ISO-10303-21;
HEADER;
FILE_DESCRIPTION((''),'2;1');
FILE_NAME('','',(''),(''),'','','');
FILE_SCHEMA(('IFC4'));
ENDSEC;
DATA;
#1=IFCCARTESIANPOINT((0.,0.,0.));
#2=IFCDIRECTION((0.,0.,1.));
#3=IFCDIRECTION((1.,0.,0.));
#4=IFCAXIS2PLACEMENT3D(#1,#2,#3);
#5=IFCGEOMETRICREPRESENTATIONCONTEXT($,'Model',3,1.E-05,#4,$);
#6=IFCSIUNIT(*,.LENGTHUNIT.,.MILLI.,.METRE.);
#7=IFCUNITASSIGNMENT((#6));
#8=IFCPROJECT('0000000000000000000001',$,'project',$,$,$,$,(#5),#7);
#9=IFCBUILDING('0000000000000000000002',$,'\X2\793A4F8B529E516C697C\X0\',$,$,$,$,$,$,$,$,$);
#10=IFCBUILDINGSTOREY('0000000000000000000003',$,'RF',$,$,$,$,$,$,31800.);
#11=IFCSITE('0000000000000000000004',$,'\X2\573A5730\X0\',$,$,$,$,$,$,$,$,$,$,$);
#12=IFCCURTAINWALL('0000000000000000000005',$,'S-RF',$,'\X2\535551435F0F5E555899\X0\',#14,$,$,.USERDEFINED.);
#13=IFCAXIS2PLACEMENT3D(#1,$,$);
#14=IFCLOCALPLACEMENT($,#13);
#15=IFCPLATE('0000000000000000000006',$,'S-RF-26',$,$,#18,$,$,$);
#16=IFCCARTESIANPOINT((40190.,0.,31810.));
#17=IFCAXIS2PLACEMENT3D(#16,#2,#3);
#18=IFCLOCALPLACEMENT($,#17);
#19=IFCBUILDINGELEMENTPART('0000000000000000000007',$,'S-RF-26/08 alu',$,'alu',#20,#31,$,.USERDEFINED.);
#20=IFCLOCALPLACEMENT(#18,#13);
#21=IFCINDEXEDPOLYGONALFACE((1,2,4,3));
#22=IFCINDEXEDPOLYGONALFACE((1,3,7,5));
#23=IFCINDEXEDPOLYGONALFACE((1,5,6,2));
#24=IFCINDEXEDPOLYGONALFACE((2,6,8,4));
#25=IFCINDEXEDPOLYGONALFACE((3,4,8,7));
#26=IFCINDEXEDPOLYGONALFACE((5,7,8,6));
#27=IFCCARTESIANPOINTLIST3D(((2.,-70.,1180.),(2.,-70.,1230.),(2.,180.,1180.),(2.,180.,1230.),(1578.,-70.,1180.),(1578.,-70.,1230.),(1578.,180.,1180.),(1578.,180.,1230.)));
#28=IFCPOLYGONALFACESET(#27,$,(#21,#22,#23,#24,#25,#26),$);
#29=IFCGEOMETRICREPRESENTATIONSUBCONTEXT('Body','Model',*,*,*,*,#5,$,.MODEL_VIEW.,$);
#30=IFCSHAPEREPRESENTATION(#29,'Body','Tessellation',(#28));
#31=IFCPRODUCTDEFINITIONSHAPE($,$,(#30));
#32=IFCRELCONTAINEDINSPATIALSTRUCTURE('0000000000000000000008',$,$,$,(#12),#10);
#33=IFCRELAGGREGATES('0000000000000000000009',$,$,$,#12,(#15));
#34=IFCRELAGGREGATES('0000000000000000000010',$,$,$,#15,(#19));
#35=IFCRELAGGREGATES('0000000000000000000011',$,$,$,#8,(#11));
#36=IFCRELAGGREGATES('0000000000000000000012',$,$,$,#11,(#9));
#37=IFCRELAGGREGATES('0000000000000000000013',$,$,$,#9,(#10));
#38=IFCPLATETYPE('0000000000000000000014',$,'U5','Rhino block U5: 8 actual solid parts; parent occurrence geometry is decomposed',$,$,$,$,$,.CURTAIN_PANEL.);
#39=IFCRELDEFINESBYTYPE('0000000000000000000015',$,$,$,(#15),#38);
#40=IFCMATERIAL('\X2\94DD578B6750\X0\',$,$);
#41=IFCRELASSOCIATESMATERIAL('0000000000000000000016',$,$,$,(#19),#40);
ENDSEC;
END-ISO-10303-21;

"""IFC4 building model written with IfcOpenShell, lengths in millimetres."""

from ifc_helpers import new_model, si_unit, frame, frame_2d, origin, origin_with_axes, place, context, subcontext, project, spatial, rectangle, extrude, source, transform, mapped, material, type_object, element, aggregate, save


model = new_model("IFC4")

# Units and contexts
model_context = context("Model", 3, precision=1e-05, world=origin_with_axes())
body_context = subcontext(model_context, "Body", "Model", "MODEL_VIEW")
ifc_project = project(units=[si_unit("LENGTHUNIT", "METRE", prefix="MILLI")], contexts=[model_context])

# Site, building, storey
site = spatial("IfcSite", under=ifc_project, Name="场地")
building = spatial("IfcBuilding", under=site, Name="示例办公楼")
storey = spatial("IfcBuildingStorey", under=building, Name="RF", Elevation=31800.0)

# Curtain wall, plate, building element part
curtain_wall = element("IfcCurtainWall", 1, inside=storey, Name="S-RF", ObjectType="单元式幕墙", PredefinedType="USERDEFINED")
plate_type = type_object("IfcPlateType", Name="U5", Description="Rhino block U5: 8 actual solid parts; parent occurrence geometry is decomposed", PredefinedType="CURTAIN_PANEL")
ifc_material_1 = material(Name="铝型材")
plate_1_placement = place(None, frame((40190.0, 0.0, 31810.0), z_axis=(0.0, 0.0, 1.0), x_axis=(1.0, 0.0, 0.0)))
plate_1 = element("IfcPlate", 2, at=plate_1_placement, type_object=plate_type, Name="S-RF-26")
aggregate(curtain_wall, [plate_1])
shared_shape_1 = source(origin(), body_context, "Body", "SweptSolid", [
    extrude(rectangle(XDim=1576.0, YDim=250.0, at=frame_2d((790.0, 55.0))), frame((0.0, 0.0, 1180.0)), (0.0, 0.0, 1.0), 50.0),
])
building_element_part_1_placement = place(plate_1_placement, origin())
building_element_part_1 = element("IfcBuildingElementPart", 3, at=building_element_part_1_placement, material=ifc_material_1, Name="S-RF-26/08 alu", ObjectType="alu", PredefinedType="USERDEFINED", context=body_context, shape_type="MappedRepresentation", body=[
    mapped(shared_shape_1, transform((0.0, 0.0, 0.0))),
])
aggregate(plate_1, [building_element_part_1])

save(model, "model.ifc")
